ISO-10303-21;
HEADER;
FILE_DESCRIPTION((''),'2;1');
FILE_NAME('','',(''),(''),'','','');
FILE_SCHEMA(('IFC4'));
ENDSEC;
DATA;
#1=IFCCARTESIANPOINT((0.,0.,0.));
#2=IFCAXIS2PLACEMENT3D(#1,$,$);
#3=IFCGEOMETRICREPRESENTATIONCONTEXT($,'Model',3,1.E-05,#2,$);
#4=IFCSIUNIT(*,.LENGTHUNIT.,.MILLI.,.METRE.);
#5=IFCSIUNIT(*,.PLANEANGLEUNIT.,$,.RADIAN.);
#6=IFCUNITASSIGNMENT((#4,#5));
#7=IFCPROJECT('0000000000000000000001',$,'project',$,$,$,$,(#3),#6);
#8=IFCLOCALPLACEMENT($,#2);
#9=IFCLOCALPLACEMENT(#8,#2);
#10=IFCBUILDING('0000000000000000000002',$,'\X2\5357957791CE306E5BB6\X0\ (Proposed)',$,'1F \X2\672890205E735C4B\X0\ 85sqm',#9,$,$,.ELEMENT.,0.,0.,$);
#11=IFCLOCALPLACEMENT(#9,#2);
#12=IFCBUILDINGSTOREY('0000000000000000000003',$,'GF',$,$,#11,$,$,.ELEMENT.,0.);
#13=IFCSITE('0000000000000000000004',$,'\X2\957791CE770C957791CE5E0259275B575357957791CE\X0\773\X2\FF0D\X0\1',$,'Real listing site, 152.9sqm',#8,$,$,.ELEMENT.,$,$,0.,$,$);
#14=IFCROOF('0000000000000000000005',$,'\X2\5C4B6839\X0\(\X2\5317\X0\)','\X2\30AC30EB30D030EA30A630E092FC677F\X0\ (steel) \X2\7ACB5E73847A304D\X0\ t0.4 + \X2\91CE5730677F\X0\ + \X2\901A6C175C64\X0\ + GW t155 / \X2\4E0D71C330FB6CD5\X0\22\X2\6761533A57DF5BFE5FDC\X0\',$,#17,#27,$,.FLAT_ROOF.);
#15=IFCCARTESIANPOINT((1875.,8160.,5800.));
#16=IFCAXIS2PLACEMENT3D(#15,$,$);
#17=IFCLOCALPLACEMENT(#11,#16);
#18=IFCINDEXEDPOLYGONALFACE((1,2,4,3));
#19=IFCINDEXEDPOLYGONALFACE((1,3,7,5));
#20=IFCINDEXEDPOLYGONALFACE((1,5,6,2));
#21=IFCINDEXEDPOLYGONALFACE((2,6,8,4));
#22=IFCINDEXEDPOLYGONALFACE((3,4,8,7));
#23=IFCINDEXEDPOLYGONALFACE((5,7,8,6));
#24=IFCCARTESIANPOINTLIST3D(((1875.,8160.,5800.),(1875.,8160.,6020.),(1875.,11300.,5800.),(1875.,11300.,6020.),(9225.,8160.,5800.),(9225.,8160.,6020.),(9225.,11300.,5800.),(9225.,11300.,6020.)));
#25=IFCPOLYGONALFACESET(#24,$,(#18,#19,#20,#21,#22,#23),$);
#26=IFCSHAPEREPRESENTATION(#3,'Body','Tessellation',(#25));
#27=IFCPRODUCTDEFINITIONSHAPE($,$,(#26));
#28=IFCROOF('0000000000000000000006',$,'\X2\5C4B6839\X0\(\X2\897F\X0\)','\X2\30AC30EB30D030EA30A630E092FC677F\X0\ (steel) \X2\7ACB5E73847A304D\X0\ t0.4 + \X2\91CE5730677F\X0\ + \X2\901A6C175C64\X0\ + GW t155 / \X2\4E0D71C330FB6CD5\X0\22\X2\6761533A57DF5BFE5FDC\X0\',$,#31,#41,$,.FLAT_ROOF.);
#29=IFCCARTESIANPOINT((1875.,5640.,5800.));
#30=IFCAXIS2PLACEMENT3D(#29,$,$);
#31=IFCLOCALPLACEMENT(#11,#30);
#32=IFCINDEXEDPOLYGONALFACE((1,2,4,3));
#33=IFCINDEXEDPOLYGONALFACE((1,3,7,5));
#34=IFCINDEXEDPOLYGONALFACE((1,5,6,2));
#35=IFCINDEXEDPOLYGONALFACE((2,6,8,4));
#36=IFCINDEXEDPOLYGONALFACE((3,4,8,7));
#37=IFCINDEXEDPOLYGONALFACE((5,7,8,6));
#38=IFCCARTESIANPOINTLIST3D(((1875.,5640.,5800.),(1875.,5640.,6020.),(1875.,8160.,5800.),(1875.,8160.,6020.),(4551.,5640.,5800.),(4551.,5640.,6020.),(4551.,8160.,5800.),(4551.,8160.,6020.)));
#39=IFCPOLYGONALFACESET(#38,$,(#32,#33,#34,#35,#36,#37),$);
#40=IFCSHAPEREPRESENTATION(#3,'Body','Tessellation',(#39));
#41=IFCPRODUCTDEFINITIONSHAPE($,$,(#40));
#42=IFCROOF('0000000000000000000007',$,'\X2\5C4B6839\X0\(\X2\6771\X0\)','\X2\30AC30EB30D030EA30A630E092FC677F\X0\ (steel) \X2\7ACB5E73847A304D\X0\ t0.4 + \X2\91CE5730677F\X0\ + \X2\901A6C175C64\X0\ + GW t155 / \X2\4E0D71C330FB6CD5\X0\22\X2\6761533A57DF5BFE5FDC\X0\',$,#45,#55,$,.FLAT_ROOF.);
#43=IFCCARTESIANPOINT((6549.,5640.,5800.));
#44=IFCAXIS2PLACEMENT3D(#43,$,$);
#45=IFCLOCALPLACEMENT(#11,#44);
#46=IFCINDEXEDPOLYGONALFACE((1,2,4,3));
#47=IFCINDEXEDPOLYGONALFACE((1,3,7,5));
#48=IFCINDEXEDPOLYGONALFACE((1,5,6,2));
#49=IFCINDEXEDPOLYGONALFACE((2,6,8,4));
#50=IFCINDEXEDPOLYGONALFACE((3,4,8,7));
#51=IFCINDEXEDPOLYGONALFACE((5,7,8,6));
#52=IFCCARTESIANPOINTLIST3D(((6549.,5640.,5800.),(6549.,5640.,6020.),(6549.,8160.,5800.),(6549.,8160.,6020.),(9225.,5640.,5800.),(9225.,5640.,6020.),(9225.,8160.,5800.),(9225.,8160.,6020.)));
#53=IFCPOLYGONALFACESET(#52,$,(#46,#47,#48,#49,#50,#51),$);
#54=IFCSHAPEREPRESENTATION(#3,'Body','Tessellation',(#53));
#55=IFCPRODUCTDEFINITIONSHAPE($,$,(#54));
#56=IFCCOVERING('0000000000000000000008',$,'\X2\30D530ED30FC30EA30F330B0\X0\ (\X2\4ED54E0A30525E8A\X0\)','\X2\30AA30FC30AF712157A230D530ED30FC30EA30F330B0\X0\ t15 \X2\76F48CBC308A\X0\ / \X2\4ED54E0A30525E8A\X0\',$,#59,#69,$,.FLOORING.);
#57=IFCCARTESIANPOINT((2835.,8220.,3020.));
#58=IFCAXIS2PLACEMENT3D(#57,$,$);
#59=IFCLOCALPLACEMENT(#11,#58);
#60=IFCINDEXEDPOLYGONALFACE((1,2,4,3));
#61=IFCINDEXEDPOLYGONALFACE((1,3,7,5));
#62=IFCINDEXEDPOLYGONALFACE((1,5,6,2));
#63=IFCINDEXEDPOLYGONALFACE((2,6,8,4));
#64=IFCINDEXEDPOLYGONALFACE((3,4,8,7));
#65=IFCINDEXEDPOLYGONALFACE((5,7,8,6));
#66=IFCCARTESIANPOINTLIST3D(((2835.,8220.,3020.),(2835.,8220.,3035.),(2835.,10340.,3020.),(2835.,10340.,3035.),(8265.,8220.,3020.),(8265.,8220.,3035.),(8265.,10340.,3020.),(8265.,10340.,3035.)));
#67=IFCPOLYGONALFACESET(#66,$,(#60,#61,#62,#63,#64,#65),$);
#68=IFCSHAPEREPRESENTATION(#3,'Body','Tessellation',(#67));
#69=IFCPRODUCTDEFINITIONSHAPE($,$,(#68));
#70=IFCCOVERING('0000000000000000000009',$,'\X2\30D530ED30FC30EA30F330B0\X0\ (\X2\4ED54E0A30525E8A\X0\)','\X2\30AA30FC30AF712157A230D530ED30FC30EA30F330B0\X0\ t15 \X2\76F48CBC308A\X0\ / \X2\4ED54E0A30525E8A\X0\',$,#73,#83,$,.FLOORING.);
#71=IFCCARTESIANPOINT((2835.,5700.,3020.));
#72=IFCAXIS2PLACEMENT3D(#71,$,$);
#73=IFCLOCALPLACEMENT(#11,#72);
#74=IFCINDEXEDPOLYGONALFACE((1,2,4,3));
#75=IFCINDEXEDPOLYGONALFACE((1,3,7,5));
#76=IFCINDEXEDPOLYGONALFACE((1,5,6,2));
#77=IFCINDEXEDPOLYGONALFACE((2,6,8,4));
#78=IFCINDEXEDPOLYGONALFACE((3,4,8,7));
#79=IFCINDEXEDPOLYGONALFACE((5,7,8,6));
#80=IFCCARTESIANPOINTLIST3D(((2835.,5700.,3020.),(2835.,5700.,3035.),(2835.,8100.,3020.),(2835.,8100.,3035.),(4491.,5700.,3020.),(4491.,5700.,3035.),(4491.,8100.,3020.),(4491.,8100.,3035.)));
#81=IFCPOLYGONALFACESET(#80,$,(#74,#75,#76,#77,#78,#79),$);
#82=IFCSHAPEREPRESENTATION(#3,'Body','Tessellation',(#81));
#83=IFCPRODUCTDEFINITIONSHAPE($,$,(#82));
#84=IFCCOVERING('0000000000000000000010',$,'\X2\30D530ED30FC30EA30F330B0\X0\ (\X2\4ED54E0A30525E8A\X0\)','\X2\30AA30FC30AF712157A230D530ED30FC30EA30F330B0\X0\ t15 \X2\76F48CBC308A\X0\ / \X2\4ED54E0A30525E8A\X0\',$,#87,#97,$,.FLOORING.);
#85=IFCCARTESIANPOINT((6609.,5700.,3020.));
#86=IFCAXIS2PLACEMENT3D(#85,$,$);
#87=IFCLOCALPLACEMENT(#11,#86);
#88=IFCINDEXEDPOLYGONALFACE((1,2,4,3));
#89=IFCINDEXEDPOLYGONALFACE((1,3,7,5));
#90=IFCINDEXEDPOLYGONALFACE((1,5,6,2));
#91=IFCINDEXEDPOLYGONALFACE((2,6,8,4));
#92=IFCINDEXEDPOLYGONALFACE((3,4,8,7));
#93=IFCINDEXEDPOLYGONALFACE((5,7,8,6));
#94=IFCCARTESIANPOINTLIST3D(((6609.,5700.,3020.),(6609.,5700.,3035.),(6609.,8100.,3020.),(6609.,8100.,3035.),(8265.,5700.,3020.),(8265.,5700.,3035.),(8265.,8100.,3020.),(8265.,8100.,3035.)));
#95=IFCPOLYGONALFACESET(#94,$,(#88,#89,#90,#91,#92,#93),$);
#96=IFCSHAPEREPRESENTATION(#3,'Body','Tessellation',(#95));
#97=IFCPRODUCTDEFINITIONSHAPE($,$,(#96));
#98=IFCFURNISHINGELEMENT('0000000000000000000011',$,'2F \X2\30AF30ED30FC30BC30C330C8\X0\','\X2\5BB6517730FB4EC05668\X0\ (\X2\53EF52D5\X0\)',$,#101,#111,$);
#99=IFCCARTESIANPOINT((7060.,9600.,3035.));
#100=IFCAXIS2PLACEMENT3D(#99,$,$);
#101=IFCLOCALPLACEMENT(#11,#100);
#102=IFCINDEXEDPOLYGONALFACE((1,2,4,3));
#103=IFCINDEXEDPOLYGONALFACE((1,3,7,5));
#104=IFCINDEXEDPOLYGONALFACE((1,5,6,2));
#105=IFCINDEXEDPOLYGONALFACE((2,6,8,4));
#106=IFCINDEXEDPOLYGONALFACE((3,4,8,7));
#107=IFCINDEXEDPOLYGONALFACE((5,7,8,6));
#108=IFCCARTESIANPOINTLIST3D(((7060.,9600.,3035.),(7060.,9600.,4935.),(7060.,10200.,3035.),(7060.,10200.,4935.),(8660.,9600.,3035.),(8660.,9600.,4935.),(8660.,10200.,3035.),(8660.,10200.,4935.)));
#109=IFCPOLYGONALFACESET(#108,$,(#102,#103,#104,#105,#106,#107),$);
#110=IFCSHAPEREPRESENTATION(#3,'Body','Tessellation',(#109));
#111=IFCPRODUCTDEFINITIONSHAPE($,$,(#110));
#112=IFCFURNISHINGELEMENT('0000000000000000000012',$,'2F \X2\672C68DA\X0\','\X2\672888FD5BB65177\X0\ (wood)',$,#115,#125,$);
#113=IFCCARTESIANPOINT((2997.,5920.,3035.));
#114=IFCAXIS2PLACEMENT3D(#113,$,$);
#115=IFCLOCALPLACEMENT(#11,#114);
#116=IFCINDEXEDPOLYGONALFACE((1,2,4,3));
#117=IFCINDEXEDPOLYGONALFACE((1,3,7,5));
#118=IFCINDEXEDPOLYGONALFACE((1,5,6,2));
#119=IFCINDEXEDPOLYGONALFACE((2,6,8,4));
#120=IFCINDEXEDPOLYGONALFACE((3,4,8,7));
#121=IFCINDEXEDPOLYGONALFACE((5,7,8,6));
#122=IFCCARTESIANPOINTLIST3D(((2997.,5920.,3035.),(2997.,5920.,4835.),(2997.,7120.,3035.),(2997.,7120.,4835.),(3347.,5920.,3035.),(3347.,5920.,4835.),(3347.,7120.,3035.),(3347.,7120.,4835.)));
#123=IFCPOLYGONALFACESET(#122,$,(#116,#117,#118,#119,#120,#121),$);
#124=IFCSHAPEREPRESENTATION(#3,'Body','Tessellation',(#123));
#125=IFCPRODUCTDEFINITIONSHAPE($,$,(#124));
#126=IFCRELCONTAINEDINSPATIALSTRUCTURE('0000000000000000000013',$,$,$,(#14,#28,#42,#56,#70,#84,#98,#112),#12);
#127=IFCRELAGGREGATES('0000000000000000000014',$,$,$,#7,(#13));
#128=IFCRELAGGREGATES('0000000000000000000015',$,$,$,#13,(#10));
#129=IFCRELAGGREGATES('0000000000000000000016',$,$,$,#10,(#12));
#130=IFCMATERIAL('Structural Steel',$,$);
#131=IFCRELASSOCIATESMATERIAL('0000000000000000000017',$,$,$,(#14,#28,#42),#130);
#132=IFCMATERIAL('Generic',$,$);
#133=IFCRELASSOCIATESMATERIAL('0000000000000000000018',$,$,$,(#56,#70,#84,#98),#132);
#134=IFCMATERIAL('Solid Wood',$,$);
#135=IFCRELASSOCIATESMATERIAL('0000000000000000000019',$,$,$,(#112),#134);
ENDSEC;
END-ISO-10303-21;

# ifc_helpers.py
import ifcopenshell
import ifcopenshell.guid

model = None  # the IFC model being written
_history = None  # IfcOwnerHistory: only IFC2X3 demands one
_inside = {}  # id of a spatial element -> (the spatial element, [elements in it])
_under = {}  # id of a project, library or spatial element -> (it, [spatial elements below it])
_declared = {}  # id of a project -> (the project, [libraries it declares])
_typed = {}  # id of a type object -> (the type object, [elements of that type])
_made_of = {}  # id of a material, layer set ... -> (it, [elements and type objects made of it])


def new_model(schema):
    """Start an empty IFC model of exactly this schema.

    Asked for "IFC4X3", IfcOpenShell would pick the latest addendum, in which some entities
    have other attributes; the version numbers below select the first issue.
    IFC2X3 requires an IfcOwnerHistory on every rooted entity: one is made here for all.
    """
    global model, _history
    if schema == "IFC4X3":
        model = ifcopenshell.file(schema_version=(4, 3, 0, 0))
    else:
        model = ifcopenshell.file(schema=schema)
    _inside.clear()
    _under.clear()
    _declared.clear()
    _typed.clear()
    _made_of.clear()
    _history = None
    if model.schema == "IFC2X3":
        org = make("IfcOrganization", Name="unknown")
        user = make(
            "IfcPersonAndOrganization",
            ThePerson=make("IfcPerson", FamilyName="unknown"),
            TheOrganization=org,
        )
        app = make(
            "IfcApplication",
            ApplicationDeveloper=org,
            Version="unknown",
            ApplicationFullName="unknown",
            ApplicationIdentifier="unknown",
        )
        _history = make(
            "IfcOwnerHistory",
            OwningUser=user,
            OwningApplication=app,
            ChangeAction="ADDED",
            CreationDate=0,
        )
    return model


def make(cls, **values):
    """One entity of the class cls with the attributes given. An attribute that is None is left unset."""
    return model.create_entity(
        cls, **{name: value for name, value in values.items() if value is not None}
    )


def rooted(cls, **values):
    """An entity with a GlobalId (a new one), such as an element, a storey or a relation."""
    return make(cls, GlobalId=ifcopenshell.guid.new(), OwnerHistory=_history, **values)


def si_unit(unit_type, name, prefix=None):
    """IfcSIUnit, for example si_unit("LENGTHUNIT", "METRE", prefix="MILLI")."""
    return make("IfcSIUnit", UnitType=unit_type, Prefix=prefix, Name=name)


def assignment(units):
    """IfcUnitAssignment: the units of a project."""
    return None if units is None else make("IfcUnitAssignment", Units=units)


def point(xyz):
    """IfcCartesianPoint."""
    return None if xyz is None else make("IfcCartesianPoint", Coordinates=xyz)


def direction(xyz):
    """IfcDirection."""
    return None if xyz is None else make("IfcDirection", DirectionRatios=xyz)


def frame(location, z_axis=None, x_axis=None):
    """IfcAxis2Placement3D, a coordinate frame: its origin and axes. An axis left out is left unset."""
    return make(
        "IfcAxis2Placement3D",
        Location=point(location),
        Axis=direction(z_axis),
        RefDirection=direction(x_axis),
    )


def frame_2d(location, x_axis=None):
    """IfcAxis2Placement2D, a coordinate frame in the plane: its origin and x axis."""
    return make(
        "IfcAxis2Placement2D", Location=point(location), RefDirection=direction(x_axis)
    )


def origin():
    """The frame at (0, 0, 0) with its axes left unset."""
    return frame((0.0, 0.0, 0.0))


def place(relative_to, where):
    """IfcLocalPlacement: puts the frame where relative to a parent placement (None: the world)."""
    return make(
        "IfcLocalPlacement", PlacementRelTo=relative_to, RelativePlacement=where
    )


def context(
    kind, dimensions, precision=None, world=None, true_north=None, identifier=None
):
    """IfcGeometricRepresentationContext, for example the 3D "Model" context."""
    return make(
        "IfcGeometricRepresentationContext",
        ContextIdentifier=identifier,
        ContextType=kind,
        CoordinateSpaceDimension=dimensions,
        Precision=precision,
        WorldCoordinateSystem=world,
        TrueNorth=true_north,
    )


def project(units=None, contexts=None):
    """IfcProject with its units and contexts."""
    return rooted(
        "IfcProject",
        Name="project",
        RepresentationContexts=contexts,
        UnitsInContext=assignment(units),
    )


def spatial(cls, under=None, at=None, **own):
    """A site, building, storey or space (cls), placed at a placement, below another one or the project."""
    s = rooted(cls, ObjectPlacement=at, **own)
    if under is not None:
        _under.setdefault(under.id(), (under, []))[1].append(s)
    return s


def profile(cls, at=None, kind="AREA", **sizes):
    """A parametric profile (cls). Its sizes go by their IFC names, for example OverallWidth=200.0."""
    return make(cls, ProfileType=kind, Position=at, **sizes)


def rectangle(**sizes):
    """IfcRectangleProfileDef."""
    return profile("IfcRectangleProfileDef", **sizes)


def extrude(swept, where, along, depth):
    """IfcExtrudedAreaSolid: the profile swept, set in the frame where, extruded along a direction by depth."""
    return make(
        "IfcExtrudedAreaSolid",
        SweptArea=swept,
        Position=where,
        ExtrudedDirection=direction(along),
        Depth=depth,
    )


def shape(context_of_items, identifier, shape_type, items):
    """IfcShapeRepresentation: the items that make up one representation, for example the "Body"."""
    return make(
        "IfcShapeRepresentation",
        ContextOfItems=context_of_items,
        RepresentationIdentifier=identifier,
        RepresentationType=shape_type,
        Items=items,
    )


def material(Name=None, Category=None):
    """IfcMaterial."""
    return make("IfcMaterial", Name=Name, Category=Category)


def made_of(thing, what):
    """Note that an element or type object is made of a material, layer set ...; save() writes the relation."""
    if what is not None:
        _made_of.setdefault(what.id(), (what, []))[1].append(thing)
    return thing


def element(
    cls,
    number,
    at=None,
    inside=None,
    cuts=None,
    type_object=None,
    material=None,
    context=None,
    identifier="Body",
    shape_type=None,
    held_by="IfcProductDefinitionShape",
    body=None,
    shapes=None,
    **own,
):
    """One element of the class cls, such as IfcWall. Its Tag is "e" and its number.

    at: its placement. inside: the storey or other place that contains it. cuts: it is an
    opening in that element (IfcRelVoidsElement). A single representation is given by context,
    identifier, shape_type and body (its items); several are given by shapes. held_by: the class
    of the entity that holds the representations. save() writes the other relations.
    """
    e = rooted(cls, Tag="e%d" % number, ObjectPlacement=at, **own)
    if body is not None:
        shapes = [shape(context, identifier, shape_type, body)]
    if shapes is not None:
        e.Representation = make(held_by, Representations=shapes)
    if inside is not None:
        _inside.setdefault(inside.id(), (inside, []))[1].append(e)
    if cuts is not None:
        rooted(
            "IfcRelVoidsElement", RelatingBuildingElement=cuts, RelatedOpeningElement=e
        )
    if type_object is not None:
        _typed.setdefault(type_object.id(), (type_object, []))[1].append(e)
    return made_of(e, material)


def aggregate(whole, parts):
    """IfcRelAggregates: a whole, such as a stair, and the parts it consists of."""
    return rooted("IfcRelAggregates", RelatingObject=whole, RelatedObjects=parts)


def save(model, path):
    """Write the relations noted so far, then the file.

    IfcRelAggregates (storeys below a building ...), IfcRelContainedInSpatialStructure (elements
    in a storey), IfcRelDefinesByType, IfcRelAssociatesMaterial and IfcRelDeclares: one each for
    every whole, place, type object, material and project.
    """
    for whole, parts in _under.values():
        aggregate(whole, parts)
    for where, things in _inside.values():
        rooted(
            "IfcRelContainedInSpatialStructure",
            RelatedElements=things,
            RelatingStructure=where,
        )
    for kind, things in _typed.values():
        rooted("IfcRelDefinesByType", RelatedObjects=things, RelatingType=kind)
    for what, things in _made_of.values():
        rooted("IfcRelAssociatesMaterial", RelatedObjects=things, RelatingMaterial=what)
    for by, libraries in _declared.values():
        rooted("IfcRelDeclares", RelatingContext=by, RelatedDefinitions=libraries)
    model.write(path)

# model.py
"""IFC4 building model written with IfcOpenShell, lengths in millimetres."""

from ifc_helpers import new_model, si_unit, frame, frame_2d, origin, place, context, project, spatial, rectangle, extrude, material, element, save


model = new_model("IFC4")

# Units and contexts
model_context = context("Model", 3, precision=1e-05, world=origin())
ifc_project = project(units=[si_unit("LENGTHUNIT", "METRE", prefix="MILLI"), si_unit("PLANEANGLEUNIT", "RADIAN")], contexts=[model_context])

# Site, building, storey
site_placement = place(None, origin())
site = spatial("IfcSite", under=ifc_project, at=site_placement, Name="長野県長野市大字南長野773－1", ObjectType="Real listing site, 152.9sqm", CompositionType="ELEMENT", RefElevation=0.0)
building_placement = place(site_placement, origin())
building = spatial("IfcBuilding", under=site, at=building_placement, Name="南長野の家 (Proposed)", ObjectType="1F 木造平屋 85sqm", CompositionType="ELEMENT", ElevationOfRefHeight=0.0, ElevationOfTerrain=0.0)
storey_placement = place(building_placement, origin())
storey = spatial("IfcBuildingStorey", under=building, at=storey_placement, Name="GF", CompositionType="ELEMENT", Elevation=0.0)

# Shared definitions
ifc_material_1 = material(Name="Solid Wood")

# Shared definitions
ifc_material_2 = material(Name="Generic")

# Roofs
ifc_material_3 = material(Name="Structural Steel")
for number, where, name in (
    (1, (1875.0, 8160.0, 5800.0), "屋根(北)"),
):
    element("IfcRoof", number, at=place(storey_placement, frame(where)), inside=storey, material=ifc_material_3, Name=name, Description="ガルバリウム鋼板 (steel) 立平葺き t0.4 + 野地板 + 通気層 + GW t155 / 不燃・法22条区域対応", PredefinedType="FLAT_ROOF", context=model_context, shape_type="SweptSolid", body=[
        extrude(rectangle(XDim=7350.0, YDim=3140.0, at=frame_2d((3675.0, 1570.0))), frame((1875.0, 8160.0, 5800.0)), (0.0, 0.0, 1.0), 220.0),
    ])
roof_1_placement = place(storey_placement, frame((1875.0, 5640.0, 5800.0)))
element("IfcRoof", 2, at=roof_1_placement, inside=storey, material=ifc_material_3, Name="屋根(西)", Description="ガルバリウム鋼板 (steel) 立平葺き t0.4 + 野地板 + 通気層 + GW t155 / 不燃・法22条区域対応", PredefinedType="FLAT_ROOF", context=model_context, shape_type="SweptSolid", body=[
    extrude(rectangle(XDim=2676.0, YDim=2520.0, at=frame_2d((1338.0, 1260.0))), frame((1875.0, 5640.0, 5800.0)), (0.0, 0.0, 1.0), 220.0),
])
roof_2_placement = place(storey_placement, frame((6549.0, 5640.0, 5800.0)))
element("IfcRoof", 3, at=roof_2_placement, inside=storey, material=ifc_material_3, Name="屋根(東)", Description="ガルバリウム鋼板 (steel) 立平葺き t0.4 + 野地板 + 通気層 + GW t155 / 不燃・法22条区域対応", PredefinedType="FLAT_ROOF", context=model_context, shape_type="SweptSolid", body=[
    extrude(rectangle(XDim=2676.0, YDim=2520.0, at=frame_2d((1338.0, 1260.0))), frame((6549.0, 5640.0, 5800.0)), (0.0, 0.0, 1.0), 220.0),
])

# Coverings
covering_1_placement = place(storey_placement, frame((2835.0, 8220.0, 3020.0)))
element("IfcCovering", 4, at=covering_1_placement, inside=storey, material=ifc_material_2, Name="フローリング (仕上げ床)", Description="オーク無垢フローリング t15 直貼り / 仕上げ床", PredefinedType="FLOORING", context=model_context, shape_type="SweptSolid", body=[
    extrude(rectangle(XDim=5430.0, YDim=2120.0, at=frame_2d((2715.0, 1060.0))), frame((2835.0, 8220.0, 3020.0)), (0.0, 0.0, 1.0), 15.0),
])
covering_2_placement = place(storey_placement, frame((2835.0, 5700.0, 3020.0)))
element("IfcCovering", 5, at=covering_2_placement, inside=storey, material=ifc_material_2, Name="フローリング (仕上げ床)", Description="オーク無垢フローリング t15 直貼り / 仕上げ床", PredefinedType="FLOORING", context=model_context, shape_type="SweptSolid", body=[
    extrude(rectangle(XDim=1656.0, YDim=2400.0, at=frame_2d((828.0, 1200.0))), frame((2835.0, 5700.0, 3020.0)), (0.0, 0.0, 1.0), 15.0),
])
covering_3_placement = place(storey_placement, frame((6609.0, 5700.0, 3020.0)))
element("IfcCovering", 6, at=covering_3_placement, inside=storey, material=ifc_material_2, Name="フローリング (仕上げ床)", Description="オーク無垢フローリング t15 直貼り / 仕上げ床", PredefinedType="FLOORING", context=model_context, shape_type="SweptSolid", body=[
    extrude(rectangle(XDim=1656.0, YDim=2400.0, at=frame_2d((828.0, 1200.0))), frame((6609.0, 5700.0, 3020.0)), (0.0, 0.0, 1.0), 15.0),
])

# Furnishing elements
furnishing_1_placement = place(storey_placement, frame((7060.0, 9600.0, 3035.0)))
element("IfcFurnishingElement", 7, at=furnishing_1_placement, inside=storey, material=ifc_material_2, Name="2F クローゼット", Description="家具・什器 (可動)", context=model_context, shape_type="SweptSolid", body=[
    extrude(rectangle(XDim=1600.0, YDim=600.0, at=frame_2d((800.0, 300.0))), frame((7060.0, 9600.0, 3035.0)), (0.0, 0.0, 1.0), 1900.0),
])
furnishing_2_placement = place(storey_placement, frame((2997.0, 5920.0, 3035.0)))
element("IfcFurnishingElement", 8, at=furnishing_2_placement, inside=storey, material=ifc_material_1, Name="2F 本棚", Description="木製家具 (wood)", context=model_context, shape_type="SweptSolid", body=[
    extrude(rectangle(XDim=350.0, YDim=1200.0, at=frame_2d((175.0, 600.0))), frame((2997.0, 5920.0, 3035.0)), (0.0, 0.0, 1.0), 1800.0),
])

save(model, "model.ifc")
